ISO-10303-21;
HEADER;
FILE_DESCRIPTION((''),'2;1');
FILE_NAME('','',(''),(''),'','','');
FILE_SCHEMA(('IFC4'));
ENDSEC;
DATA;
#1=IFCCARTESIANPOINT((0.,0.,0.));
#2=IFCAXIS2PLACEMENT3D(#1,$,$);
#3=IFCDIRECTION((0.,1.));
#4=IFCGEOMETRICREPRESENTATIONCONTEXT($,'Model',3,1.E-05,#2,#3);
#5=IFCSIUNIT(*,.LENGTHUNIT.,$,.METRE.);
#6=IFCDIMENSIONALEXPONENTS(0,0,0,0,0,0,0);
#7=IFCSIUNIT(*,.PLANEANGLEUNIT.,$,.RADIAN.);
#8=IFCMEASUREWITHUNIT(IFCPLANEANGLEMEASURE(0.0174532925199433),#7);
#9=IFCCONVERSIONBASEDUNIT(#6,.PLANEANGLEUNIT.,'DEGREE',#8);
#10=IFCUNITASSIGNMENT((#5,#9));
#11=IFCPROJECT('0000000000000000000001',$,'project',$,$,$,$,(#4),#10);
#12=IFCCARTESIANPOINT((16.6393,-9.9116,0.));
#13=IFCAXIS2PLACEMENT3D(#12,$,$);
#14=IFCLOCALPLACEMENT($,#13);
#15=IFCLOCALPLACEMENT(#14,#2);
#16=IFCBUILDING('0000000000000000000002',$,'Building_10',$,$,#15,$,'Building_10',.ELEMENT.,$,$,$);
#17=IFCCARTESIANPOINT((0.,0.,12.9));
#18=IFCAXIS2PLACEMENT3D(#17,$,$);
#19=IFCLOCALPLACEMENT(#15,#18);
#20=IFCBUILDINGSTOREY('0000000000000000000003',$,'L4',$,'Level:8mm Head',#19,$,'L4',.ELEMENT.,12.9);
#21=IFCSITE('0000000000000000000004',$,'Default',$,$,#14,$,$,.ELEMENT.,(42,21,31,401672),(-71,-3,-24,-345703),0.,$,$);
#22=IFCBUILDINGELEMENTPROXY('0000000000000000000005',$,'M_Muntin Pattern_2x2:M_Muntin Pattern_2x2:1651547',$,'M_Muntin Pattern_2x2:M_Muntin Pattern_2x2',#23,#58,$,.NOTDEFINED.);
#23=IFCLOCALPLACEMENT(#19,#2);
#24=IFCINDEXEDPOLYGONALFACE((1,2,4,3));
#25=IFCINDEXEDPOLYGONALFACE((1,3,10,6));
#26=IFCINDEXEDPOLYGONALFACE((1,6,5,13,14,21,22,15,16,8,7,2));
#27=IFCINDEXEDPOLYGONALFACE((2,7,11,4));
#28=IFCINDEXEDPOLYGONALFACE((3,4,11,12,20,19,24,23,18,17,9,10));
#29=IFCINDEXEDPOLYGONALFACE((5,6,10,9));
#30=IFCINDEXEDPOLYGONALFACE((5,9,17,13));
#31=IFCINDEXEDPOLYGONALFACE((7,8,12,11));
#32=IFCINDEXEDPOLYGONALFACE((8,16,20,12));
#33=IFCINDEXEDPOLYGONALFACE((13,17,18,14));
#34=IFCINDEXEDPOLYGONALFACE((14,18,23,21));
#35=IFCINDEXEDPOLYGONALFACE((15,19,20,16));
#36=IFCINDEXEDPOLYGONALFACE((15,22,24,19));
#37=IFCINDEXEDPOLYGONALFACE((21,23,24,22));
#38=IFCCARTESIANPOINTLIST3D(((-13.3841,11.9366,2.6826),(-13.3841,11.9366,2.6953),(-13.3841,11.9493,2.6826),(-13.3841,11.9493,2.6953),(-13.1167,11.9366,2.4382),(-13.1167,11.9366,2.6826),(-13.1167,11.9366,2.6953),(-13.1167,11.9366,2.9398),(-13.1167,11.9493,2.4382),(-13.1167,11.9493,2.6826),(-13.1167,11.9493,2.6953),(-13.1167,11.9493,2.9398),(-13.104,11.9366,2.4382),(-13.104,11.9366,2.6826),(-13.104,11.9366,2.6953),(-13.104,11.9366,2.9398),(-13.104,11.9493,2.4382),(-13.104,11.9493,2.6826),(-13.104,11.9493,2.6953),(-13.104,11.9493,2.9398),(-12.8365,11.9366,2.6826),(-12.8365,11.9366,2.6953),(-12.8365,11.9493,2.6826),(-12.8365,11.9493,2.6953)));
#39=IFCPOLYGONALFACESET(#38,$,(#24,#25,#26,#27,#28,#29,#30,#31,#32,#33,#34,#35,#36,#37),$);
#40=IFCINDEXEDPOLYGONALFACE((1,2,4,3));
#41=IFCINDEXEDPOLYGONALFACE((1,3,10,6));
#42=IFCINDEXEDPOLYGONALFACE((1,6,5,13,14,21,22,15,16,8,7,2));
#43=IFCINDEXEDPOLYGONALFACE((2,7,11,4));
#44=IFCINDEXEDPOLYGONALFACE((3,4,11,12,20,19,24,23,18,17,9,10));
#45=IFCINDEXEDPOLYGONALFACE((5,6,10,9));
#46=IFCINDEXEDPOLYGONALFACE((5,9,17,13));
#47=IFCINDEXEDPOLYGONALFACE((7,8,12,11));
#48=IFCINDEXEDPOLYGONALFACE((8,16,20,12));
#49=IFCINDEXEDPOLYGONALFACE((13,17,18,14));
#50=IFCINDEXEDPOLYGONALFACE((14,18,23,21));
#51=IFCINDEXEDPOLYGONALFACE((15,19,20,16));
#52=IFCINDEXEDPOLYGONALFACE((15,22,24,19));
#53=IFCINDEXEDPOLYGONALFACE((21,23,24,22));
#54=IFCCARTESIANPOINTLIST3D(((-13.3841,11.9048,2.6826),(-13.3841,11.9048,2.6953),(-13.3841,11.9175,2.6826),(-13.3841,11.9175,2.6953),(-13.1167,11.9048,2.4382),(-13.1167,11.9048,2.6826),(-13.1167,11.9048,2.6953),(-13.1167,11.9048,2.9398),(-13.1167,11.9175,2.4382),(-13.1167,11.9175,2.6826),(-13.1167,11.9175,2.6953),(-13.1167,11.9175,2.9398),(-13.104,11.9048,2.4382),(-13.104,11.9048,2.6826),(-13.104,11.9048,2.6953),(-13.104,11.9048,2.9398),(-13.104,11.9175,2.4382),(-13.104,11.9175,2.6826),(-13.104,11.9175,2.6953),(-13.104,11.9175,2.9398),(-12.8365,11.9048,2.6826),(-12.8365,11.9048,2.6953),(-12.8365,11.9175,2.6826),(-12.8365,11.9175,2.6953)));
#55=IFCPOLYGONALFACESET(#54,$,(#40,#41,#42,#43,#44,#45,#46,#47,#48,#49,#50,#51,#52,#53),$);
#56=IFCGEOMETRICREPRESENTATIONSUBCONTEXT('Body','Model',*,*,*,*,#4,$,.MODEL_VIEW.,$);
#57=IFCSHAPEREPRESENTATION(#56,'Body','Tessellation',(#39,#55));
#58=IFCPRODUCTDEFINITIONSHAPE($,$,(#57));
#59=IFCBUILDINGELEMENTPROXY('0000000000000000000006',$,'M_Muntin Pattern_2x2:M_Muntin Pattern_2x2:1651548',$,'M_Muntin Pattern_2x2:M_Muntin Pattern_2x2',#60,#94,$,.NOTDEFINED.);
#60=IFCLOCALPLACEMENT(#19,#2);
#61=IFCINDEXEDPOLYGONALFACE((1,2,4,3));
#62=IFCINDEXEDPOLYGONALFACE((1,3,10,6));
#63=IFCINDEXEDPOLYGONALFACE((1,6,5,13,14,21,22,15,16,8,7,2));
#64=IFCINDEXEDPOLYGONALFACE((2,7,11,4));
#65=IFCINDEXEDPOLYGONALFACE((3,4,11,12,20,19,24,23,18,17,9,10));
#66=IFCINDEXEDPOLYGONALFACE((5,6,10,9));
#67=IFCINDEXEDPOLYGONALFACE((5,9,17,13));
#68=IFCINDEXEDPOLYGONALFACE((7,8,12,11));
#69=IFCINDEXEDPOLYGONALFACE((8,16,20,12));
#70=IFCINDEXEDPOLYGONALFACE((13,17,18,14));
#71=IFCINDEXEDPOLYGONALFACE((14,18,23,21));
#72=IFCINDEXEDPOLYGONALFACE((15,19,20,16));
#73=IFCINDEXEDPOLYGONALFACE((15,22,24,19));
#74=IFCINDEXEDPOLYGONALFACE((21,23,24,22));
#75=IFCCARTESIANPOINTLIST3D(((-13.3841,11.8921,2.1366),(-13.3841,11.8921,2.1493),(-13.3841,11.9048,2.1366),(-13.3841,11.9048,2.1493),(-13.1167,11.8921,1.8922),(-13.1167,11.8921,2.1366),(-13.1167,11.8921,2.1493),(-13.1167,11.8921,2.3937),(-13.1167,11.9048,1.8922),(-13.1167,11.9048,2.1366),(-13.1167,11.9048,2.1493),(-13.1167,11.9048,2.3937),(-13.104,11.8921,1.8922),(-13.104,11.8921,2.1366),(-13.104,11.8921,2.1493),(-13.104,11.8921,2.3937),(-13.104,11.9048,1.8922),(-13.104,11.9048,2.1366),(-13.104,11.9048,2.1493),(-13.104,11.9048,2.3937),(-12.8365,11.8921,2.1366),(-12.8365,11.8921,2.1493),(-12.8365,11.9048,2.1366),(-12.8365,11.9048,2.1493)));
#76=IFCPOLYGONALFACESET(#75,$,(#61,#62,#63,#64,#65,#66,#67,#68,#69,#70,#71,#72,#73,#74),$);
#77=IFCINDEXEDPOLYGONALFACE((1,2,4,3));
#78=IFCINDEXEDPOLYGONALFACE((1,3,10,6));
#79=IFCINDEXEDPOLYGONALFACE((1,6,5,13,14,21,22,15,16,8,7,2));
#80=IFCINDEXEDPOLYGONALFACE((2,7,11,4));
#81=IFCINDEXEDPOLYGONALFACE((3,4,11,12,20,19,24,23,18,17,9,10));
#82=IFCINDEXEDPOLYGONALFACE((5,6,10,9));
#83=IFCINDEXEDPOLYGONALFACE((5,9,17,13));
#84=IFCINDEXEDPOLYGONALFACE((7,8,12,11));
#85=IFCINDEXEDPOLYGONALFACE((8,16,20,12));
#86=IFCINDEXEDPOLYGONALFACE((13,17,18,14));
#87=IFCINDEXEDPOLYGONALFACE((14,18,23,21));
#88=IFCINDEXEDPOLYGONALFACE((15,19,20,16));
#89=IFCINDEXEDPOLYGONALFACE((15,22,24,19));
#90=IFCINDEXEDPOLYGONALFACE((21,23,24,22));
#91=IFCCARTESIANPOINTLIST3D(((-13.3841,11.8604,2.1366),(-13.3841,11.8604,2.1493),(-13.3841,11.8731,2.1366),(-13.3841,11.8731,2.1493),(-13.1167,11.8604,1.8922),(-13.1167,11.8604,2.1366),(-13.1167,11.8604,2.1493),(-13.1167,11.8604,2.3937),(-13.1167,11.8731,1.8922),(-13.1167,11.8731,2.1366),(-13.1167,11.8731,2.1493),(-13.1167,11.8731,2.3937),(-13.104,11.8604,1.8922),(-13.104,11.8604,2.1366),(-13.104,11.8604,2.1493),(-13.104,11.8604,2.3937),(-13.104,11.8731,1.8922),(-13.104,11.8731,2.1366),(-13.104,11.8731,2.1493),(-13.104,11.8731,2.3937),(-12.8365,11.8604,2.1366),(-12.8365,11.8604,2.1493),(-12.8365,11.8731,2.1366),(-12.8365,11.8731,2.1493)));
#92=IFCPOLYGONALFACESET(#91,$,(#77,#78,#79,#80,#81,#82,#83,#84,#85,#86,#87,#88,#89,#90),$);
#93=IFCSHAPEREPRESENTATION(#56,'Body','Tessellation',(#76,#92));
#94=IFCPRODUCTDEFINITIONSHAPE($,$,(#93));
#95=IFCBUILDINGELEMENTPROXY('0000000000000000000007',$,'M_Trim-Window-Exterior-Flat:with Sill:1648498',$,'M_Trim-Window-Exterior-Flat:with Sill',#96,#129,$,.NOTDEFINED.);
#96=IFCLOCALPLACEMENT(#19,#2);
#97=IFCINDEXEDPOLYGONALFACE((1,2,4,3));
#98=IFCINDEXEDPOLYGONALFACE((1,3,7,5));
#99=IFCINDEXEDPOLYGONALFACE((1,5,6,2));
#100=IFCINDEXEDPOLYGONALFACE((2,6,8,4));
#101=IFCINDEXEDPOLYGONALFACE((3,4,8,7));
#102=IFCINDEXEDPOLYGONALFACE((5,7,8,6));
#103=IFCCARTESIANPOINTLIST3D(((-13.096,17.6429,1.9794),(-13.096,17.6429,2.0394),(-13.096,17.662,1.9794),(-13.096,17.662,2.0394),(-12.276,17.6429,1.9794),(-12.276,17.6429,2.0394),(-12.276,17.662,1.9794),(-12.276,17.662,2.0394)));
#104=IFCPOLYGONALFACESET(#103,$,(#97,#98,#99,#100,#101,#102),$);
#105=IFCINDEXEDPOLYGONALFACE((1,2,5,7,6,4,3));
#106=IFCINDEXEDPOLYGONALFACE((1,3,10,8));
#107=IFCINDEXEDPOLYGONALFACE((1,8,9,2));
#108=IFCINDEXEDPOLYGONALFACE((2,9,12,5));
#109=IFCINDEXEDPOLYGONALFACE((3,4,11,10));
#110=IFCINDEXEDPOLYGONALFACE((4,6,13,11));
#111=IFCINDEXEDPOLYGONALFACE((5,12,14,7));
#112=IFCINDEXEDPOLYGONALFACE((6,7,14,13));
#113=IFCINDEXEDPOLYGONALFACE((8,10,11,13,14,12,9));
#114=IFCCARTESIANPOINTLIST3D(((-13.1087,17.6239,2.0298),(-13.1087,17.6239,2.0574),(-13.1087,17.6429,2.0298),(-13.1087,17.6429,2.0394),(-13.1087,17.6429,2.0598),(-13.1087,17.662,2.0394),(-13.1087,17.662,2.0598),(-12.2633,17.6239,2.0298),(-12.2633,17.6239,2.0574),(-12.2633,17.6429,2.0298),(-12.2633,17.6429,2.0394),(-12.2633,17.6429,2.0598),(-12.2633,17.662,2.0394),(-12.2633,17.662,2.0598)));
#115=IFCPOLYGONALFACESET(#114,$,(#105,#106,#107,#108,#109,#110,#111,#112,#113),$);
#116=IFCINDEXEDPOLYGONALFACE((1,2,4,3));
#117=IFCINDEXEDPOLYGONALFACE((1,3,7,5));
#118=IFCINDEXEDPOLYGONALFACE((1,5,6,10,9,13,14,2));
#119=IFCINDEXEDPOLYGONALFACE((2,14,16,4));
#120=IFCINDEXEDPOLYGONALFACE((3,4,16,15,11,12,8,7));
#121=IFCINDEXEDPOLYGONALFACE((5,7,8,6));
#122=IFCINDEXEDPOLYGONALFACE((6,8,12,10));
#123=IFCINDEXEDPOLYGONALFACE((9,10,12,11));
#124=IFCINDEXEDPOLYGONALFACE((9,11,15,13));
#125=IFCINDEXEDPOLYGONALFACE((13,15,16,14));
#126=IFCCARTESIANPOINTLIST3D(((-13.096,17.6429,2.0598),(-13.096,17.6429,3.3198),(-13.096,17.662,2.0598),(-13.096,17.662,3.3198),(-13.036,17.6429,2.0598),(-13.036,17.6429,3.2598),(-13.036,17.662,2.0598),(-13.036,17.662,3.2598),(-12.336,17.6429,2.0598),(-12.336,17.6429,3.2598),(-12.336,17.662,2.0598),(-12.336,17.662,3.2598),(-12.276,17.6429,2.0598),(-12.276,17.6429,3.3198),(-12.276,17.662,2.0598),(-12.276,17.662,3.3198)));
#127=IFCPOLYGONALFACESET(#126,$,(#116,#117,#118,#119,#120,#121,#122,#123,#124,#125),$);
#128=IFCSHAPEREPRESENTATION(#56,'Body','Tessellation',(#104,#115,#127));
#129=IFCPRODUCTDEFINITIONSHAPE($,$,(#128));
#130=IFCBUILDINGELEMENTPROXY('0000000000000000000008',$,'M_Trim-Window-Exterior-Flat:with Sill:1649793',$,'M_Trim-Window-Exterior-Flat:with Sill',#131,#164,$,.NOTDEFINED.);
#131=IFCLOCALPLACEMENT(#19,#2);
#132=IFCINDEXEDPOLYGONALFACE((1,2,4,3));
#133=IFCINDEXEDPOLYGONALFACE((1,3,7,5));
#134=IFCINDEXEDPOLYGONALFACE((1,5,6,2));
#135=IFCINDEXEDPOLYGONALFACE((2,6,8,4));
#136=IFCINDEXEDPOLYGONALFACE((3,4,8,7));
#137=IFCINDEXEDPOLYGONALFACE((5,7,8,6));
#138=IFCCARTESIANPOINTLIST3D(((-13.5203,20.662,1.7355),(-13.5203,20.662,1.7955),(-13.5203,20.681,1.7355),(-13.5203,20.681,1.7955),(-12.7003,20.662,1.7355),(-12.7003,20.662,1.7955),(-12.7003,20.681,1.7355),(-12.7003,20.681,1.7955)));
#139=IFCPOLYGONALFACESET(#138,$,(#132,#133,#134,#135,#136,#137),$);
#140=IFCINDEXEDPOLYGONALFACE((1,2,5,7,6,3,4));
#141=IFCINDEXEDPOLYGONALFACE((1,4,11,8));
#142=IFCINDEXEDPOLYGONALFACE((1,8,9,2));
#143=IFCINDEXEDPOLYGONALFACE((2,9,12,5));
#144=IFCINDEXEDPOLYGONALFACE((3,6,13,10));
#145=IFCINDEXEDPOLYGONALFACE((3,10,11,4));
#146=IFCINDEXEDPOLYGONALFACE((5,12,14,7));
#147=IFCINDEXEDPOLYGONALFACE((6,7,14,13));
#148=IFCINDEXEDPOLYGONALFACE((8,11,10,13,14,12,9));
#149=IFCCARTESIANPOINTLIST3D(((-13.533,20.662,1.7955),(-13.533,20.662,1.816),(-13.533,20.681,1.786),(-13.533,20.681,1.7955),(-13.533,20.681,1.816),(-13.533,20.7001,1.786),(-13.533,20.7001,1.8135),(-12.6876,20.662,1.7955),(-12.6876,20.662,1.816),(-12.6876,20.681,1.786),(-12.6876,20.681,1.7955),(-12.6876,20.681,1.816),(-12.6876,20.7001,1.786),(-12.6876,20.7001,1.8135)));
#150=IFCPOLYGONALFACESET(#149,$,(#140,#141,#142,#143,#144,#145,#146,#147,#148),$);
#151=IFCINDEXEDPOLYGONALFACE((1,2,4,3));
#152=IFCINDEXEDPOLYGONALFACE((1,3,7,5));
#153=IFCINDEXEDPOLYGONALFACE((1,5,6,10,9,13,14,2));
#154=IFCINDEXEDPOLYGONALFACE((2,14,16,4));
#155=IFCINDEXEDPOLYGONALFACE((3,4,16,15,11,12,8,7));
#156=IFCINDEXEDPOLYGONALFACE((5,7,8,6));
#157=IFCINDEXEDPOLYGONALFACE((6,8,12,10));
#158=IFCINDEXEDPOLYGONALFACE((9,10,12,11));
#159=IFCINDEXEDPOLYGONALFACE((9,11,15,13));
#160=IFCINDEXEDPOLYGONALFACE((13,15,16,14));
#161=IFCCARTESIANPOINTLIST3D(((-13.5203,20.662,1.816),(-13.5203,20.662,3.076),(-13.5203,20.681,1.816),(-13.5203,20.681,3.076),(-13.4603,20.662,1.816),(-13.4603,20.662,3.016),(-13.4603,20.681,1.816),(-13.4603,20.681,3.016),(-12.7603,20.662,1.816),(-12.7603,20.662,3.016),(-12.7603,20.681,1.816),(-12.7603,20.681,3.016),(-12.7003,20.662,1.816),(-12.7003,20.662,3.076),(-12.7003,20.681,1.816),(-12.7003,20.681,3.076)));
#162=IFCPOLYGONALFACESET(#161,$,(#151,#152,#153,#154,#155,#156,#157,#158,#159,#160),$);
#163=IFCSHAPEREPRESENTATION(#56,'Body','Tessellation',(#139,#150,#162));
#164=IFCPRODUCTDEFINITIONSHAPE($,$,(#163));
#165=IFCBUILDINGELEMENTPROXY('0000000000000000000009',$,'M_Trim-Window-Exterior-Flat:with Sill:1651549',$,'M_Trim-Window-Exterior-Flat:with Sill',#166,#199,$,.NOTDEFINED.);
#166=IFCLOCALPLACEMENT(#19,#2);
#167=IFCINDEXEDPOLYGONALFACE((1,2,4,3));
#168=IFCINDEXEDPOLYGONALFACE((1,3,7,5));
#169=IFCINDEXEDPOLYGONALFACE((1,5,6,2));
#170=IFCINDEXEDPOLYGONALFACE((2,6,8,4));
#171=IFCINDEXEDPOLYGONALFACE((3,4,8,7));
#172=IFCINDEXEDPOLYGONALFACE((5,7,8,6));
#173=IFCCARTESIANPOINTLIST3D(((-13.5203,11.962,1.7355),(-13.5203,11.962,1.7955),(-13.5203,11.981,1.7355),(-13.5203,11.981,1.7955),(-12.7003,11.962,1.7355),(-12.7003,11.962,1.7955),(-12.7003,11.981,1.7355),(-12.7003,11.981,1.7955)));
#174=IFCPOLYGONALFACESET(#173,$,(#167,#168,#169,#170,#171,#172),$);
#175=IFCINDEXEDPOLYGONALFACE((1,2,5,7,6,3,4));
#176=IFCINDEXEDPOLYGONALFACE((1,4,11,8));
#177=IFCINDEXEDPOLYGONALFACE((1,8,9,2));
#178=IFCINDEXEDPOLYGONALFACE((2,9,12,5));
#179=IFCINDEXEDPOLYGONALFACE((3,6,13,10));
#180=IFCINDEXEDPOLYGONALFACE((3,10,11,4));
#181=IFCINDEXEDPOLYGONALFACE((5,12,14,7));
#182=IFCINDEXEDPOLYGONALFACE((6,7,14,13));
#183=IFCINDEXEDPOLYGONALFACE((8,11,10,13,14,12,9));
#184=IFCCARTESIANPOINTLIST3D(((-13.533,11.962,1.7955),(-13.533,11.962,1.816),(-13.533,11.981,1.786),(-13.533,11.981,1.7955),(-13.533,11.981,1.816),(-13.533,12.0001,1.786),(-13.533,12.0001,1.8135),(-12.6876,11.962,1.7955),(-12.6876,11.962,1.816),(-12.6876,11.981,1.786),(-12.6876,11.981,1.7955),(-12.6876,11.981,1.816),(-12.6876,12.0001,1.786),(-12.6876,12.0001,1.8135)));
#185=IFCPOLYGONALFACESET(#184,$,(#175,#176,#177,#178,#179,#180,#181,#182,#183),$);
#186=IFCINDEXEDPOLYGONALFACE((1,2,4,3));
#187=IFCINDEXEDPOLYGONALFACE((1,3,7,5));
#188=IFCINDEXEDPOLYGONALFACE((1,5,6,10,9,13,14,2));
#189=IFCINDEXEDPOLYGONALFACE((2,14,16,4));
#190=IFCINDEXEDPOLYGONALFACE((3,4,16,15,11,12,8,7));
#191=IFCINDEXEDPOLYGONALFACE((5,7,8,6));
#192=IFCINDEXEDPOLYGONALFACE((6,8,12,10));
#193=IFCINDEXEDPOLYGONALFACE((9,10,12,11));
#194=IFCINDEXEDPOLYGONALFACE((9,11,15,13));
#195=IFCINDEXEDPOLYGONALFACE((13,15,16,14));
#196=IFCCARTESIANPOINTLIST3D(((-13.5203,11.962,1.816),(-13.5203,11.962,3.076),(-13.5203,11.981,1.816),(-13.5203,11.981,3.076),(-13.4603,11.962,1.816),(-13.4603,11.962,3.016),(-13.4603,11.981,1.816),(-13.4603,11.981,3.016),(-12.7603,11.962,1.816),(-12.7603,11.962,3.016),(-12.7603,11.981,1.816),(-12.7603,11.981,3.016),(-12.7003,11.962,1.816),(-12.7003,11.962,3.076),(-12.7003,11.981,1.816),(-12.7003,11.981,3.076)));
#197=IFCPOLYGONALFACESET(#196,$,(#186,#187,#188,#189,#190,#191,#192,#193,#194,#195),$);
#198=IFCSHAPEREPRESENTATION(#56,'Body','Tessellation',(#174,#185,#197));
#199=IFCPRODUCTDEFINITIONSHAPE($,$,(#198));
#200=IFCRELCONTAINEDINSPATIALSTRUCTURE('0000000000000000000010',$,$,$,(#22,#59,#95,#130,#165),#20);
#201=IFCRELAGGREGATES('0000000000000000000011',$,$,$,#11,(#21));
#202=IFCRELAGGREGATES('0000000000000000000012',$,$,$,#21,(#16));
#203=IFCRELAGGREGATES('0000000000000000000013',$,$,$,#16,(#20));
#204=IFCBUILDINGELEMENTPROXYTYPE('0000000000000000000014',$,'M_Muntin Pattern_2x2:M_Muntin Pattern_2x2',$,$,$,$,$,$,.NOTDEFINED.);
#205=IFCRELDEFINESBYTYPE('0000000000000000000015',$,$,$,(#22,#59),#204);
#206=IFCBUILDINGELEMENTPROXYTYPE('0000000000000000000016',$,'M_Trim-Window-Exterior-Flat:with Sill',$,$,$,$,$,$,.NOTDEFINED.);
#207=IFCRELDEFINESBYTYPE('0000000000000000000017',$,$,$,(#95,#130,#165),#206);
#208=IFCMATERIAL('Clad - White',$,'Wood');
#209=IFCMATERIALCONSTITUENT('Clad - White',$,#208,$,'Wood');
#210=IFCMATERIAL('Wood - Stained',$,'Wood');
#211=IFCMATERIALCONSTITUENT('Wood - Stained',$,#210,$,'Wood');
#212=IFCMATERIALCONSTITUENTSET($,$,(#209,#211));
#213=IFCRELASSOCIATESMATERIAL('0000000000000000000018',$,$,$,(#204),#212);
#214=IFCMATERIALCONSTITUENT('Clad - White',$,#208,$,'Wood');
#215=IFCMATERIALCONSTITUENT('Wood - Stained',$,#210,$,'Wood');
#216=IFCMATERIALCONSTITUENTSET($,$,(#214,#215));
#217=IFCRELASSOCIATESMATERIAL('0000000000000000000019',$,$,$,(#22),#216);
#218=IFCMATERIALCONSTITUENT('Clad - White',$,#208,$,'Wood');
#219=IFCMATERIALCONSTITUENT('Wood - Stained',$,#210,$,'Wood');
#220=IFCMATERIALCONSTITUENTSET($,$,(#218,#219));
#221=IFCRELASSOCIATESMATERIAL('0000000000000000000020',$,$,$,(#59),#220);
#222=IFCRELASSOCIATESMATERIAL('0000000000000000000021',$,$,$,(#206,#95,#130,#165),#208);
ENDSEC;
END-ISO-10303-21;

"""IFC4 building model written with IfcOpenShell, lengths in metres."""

from ifc_helpers import new_model, entity, si_unit, converted_unit, direction, frame, origin, place, context, subcontext, project, spatial, indexed_curve, outline, extrude, source, transform, mapped, material, constituent, constituent_set, type_object, type_shapes, element, save


model = new_model("IFC4")

# Units and contexts
model_context = context("Model", 3, precision=1e-05, world=origin(), true_north=direction((0.0, 1.0)))
body_context = subcontext(model_context, "Body", "Model", "MODEL_VIEW")
ifc_project = project(units=[si_unit("LENGTHUNIT", "METRE"), converted_unit("PLANEANGLEUNIT", "DEGREE", entity("IfcPlaneAngleMeasure", 0.0174532925199433), si_unit("PLANEANGLEUNIT", "RADIAN"), dimensions=[0, 0, 0, 0, 0, 0, 0])], contexts=[model_context])

# Site, building, storey
site_placement = place(None, frame((16.6393, -9.9116, 0.0)))
site = spatial("IfcSite", under=ifc_project, at=site_placement, Name="Default", CompositionType="ELEMENT", RefLatitude=(42, 21, 31, 401672), RefLongitude=(-71, -3, -24, -345703), RefElevation=0.0)
building_placement = place(site_placement, origin())
building = spatial("IfcBuilding", under=site, at=building_placement, Name="Building_10", LongName="Building_10", CompositionType="ELEMENT")
storey_placement = place(building_placement, frame((0.0, 0.0, 12.9)))
storey = spatial("IfcBuildingStorey", under=building, at=storey_placement, Name="L4", ObjectType="Level:8mm Head", LongName="L4", CompositionType="ELEMENT", Elevation=12.9)

# Building element proxies
ifc_material_1 = material(Name="Clad - White", Category="Wood")
ifc_material_2 = material(Name="Wood - Stained", Category="Wood")
ifc_constituent_1 = constituent(ifc_material_1, Name="Clad - White", Category="Wood")
ifc_constituent_2 = constituent(ifc_material_2, Name="Wood - Stained", Category="Wood")
ifc_constituent_set_1 = constituent_set(constituents=[ifc_constituent_1, ifc_constituent_2])
building_element_proxy_type_1 = type_object("IfcBuildingElementProxyType", Name="M_Muntin Pattern_2x2:M_Muntin Pattern_2x2", PredefinedType="NOTDEFINED", material=ifc_constituent_set_1)
shared_shape_1 = source(origin(), body_context, "Body", "SweptSolid", [
    extrude(outline(indexed_curve([(0.0064, -0.0064), (0.2508, -0.0064), (0.2508, 0.0063), (0.0064, 0.0063), (0.0064, 0.2738), (-0.0063, 0.2738), (-0.0063, 0.0063), (-0.2508, 0.0063), (-0.2508, -0.0064), (-0.0063, -0.0064), (-0.0063, -0.2738), (0.0064, -0.2738), (0.0064, -0.0064)], self_intersect=False)), frame((0.0, 0.0095, 0.2508), z_axis=(0.0, 1.0, 0.0), x_axis=(0.0, 0.0, 1.0)), (0.0, 0.0, 1.0), 0.0127),
    extrude(outline(indexed_curve([(0.0064, -0.0064), (0.2508, -0.0064), (0.2508, 0.0063), (0.0064, 0.0063), (0.0064, 0.2738), (-0.0063, 0.2738), (-0.0063, 0.0063), (-0.2508, 0.0063), (-0.2508, -0.0064), (-0.0063, -0.0064), (-0.0063, -0.2738), (0.0064, -0.2738), (0.0064, -0.0064)], self_intersect=False)), frame((0.0, -0.0222, 0.2508), z_axis=(0.0, 1.0, 0.0), x_axis=(0.0, 0.0, 1.0)), (0.0, 0.0, 1.0), 0.0127),
])
type_shapes(building_element_proxy_type_1, [shared_shape_1])
ifc_constituent_3 = constituent(ifc_material_1, Name="Clad - White", Category="Wood")
ifc_constituent_4 = constituent(ifc_material_2, Name="Wood - Stained", Category="Wood")
ifc_constituent_set_2 = constituent_set(constituents=[ifc_constituent_3, ifc_constituent_4])
proxy_1_placement = place(storey_placement, frame((-13.1103, 11.927, 2.4382)))
element("IfcBuildingElementProxy", 1, at=proxy_1_placement, inside=storey, type_object=building_element_proxy_type_1, material=ifc_constituent_set_2, Name="M_Muntin Pattern_2x2:M_Muntin Pattern_2x2:1651547", ObjectType="M_Muntin Pattern_2x2:M_Muntin Pattern_2x2", PredefinedType="NOTDEFINED", context=body_context, shape_type="MappedRepresentation", body=[
    mapped(shared_shape_1, transform((0.0, 0.0, 0.0), scale=1.0)),
])
ifc_constituent_5 = constituent(ifc_material_1, Name="Clad - White", Category="Wood")
ifc_constituent_6 = constituent(ifc_material_2, Name="Wood - Stained", Category="Wood")
ifc_constituent_set_3 = constituent_set(constituents=[ifc_constituent_5, ifc_constituent_6])
proxy_2_placement = place(storey_placement, frame((-13.1103, 11.8826, 1.8922)))
element("IfcBuildingElementProxy", 2, at=proxy_2_placement, inside=storey, type_object=building_element_proxy_type_1, material=ifc_constituent_set_3, Name="M_Muntin Pattern_2x2:M_Muntin Pattern_2x2:1651548", ObjectType="M_Muntin Pattern_2x2:M_Muntin Pattern_2x2", PredefinedType="NOTDEFINED", context=body_context, shape_type="MappedRepresentation", body=[
    mapped(shared_shape_1, transform((0.0, 0.0, 0.0), scale=1.0)),
])
building_element_proxy_type_2 = type_object("IfcBuildingElementProxyType", Name="M_Trim-Window-Exterior-Flat:with Sill", PredefinedType="NOTDEFINED", material=ifc_material_1)
shared_shape_2 = source(origin(), body_context, "Body", "SweptSolid", [
    extrude(outline(indexed_curve([(-0.41, -0.03), (0.41, -0.03), (0.41, 0.03), (-0.41, 0.03), (-0.41, -0.03)], self_intersect=False)), frame((0.0, -1.2504, 0.0), z_axis=(0.0, 0.0, 1.0), x_axis=(-1.0, 0.0, 0.0)), (0.0, 0.0, 1.0), 0.0191),
    extrude(outline(indexed_curve([(-0.019, -0.0152), (0.0, -0.0152), (0.0, -0.0057), (0.019, -0.0057), (0.019, 0.0148), (0.0, 0.0148), (-0.019, 0.0123), (-0.019, -0.0152)], self_intersect=False)), frame((-0.4227, -1.2148, 0.019), z_axis=(1.0, 0.0, 0.0), x_axis=(0.0, 0.0, -1.0)), (0.0, 0.0, 1.0), 0.8454),
    extrude(outline(indexed_curve([(-0.645, -0.41), (0.615, -0.41), (0.615, -0.35), (-0.585, -0.35), (-0.585, 0.35), (0.615, 0.35), (0.615, 0.41), (-0.645, 0.41), (-0.645, -0.41)], self_intersect=False)), frame((0.0, -0.585, 0.0), z_axis=(0.0, 0.0, 1.0), x_axis=(0.0, -1.0, 0.0)), (0.0, 0.0, 1.0), 0.0191),
])
type_shapes(building_element_proxy_type_2, [shared_shape_2])
for number, where, z_axis, x_axis, name in (
    (3, (-12.686, 17.662, 3.2598), (0.0, -1.0, 0.0), (1.0, 0.0, 0.0), "M_Trim-Window-Exterior-Flat:with Sill:1648498"),
    (4, (-13.1103, 20.662, 3.016), (0.0, 1.0, 0.0), (-1.0, 0.0, 0.0), "M_Trim-Window-Exterior-Flat:with Sill:1649793"),
    (5, (-13.1103, 11.962, 3.016), (0.0, 1.0, 0.0), (-1.0, 0.0, 0.0), "M_Trim-Window-Exterior-Flat:with Sill:1651549"),
):
    element("IfcBuildingElementProxy", number, at=place(storey_placement, frame(where, z_axis=z_axis, x_axis=x_axis)), inside=storey, type_object=building_element_proxy_type_2, material=ifc_material_1, Name=name, ObjectType="M_Trim-Window-Exterior-Flat:with Sill", PredefinedType="NOTDEFINED", context=body_context, shape_type="MappedRepresentation", body=[
        mapped(shared_shape_2, transform((0.0, 0.0, 0.0), scale=1.0)),
    ])

save(model, "model.ifc")
